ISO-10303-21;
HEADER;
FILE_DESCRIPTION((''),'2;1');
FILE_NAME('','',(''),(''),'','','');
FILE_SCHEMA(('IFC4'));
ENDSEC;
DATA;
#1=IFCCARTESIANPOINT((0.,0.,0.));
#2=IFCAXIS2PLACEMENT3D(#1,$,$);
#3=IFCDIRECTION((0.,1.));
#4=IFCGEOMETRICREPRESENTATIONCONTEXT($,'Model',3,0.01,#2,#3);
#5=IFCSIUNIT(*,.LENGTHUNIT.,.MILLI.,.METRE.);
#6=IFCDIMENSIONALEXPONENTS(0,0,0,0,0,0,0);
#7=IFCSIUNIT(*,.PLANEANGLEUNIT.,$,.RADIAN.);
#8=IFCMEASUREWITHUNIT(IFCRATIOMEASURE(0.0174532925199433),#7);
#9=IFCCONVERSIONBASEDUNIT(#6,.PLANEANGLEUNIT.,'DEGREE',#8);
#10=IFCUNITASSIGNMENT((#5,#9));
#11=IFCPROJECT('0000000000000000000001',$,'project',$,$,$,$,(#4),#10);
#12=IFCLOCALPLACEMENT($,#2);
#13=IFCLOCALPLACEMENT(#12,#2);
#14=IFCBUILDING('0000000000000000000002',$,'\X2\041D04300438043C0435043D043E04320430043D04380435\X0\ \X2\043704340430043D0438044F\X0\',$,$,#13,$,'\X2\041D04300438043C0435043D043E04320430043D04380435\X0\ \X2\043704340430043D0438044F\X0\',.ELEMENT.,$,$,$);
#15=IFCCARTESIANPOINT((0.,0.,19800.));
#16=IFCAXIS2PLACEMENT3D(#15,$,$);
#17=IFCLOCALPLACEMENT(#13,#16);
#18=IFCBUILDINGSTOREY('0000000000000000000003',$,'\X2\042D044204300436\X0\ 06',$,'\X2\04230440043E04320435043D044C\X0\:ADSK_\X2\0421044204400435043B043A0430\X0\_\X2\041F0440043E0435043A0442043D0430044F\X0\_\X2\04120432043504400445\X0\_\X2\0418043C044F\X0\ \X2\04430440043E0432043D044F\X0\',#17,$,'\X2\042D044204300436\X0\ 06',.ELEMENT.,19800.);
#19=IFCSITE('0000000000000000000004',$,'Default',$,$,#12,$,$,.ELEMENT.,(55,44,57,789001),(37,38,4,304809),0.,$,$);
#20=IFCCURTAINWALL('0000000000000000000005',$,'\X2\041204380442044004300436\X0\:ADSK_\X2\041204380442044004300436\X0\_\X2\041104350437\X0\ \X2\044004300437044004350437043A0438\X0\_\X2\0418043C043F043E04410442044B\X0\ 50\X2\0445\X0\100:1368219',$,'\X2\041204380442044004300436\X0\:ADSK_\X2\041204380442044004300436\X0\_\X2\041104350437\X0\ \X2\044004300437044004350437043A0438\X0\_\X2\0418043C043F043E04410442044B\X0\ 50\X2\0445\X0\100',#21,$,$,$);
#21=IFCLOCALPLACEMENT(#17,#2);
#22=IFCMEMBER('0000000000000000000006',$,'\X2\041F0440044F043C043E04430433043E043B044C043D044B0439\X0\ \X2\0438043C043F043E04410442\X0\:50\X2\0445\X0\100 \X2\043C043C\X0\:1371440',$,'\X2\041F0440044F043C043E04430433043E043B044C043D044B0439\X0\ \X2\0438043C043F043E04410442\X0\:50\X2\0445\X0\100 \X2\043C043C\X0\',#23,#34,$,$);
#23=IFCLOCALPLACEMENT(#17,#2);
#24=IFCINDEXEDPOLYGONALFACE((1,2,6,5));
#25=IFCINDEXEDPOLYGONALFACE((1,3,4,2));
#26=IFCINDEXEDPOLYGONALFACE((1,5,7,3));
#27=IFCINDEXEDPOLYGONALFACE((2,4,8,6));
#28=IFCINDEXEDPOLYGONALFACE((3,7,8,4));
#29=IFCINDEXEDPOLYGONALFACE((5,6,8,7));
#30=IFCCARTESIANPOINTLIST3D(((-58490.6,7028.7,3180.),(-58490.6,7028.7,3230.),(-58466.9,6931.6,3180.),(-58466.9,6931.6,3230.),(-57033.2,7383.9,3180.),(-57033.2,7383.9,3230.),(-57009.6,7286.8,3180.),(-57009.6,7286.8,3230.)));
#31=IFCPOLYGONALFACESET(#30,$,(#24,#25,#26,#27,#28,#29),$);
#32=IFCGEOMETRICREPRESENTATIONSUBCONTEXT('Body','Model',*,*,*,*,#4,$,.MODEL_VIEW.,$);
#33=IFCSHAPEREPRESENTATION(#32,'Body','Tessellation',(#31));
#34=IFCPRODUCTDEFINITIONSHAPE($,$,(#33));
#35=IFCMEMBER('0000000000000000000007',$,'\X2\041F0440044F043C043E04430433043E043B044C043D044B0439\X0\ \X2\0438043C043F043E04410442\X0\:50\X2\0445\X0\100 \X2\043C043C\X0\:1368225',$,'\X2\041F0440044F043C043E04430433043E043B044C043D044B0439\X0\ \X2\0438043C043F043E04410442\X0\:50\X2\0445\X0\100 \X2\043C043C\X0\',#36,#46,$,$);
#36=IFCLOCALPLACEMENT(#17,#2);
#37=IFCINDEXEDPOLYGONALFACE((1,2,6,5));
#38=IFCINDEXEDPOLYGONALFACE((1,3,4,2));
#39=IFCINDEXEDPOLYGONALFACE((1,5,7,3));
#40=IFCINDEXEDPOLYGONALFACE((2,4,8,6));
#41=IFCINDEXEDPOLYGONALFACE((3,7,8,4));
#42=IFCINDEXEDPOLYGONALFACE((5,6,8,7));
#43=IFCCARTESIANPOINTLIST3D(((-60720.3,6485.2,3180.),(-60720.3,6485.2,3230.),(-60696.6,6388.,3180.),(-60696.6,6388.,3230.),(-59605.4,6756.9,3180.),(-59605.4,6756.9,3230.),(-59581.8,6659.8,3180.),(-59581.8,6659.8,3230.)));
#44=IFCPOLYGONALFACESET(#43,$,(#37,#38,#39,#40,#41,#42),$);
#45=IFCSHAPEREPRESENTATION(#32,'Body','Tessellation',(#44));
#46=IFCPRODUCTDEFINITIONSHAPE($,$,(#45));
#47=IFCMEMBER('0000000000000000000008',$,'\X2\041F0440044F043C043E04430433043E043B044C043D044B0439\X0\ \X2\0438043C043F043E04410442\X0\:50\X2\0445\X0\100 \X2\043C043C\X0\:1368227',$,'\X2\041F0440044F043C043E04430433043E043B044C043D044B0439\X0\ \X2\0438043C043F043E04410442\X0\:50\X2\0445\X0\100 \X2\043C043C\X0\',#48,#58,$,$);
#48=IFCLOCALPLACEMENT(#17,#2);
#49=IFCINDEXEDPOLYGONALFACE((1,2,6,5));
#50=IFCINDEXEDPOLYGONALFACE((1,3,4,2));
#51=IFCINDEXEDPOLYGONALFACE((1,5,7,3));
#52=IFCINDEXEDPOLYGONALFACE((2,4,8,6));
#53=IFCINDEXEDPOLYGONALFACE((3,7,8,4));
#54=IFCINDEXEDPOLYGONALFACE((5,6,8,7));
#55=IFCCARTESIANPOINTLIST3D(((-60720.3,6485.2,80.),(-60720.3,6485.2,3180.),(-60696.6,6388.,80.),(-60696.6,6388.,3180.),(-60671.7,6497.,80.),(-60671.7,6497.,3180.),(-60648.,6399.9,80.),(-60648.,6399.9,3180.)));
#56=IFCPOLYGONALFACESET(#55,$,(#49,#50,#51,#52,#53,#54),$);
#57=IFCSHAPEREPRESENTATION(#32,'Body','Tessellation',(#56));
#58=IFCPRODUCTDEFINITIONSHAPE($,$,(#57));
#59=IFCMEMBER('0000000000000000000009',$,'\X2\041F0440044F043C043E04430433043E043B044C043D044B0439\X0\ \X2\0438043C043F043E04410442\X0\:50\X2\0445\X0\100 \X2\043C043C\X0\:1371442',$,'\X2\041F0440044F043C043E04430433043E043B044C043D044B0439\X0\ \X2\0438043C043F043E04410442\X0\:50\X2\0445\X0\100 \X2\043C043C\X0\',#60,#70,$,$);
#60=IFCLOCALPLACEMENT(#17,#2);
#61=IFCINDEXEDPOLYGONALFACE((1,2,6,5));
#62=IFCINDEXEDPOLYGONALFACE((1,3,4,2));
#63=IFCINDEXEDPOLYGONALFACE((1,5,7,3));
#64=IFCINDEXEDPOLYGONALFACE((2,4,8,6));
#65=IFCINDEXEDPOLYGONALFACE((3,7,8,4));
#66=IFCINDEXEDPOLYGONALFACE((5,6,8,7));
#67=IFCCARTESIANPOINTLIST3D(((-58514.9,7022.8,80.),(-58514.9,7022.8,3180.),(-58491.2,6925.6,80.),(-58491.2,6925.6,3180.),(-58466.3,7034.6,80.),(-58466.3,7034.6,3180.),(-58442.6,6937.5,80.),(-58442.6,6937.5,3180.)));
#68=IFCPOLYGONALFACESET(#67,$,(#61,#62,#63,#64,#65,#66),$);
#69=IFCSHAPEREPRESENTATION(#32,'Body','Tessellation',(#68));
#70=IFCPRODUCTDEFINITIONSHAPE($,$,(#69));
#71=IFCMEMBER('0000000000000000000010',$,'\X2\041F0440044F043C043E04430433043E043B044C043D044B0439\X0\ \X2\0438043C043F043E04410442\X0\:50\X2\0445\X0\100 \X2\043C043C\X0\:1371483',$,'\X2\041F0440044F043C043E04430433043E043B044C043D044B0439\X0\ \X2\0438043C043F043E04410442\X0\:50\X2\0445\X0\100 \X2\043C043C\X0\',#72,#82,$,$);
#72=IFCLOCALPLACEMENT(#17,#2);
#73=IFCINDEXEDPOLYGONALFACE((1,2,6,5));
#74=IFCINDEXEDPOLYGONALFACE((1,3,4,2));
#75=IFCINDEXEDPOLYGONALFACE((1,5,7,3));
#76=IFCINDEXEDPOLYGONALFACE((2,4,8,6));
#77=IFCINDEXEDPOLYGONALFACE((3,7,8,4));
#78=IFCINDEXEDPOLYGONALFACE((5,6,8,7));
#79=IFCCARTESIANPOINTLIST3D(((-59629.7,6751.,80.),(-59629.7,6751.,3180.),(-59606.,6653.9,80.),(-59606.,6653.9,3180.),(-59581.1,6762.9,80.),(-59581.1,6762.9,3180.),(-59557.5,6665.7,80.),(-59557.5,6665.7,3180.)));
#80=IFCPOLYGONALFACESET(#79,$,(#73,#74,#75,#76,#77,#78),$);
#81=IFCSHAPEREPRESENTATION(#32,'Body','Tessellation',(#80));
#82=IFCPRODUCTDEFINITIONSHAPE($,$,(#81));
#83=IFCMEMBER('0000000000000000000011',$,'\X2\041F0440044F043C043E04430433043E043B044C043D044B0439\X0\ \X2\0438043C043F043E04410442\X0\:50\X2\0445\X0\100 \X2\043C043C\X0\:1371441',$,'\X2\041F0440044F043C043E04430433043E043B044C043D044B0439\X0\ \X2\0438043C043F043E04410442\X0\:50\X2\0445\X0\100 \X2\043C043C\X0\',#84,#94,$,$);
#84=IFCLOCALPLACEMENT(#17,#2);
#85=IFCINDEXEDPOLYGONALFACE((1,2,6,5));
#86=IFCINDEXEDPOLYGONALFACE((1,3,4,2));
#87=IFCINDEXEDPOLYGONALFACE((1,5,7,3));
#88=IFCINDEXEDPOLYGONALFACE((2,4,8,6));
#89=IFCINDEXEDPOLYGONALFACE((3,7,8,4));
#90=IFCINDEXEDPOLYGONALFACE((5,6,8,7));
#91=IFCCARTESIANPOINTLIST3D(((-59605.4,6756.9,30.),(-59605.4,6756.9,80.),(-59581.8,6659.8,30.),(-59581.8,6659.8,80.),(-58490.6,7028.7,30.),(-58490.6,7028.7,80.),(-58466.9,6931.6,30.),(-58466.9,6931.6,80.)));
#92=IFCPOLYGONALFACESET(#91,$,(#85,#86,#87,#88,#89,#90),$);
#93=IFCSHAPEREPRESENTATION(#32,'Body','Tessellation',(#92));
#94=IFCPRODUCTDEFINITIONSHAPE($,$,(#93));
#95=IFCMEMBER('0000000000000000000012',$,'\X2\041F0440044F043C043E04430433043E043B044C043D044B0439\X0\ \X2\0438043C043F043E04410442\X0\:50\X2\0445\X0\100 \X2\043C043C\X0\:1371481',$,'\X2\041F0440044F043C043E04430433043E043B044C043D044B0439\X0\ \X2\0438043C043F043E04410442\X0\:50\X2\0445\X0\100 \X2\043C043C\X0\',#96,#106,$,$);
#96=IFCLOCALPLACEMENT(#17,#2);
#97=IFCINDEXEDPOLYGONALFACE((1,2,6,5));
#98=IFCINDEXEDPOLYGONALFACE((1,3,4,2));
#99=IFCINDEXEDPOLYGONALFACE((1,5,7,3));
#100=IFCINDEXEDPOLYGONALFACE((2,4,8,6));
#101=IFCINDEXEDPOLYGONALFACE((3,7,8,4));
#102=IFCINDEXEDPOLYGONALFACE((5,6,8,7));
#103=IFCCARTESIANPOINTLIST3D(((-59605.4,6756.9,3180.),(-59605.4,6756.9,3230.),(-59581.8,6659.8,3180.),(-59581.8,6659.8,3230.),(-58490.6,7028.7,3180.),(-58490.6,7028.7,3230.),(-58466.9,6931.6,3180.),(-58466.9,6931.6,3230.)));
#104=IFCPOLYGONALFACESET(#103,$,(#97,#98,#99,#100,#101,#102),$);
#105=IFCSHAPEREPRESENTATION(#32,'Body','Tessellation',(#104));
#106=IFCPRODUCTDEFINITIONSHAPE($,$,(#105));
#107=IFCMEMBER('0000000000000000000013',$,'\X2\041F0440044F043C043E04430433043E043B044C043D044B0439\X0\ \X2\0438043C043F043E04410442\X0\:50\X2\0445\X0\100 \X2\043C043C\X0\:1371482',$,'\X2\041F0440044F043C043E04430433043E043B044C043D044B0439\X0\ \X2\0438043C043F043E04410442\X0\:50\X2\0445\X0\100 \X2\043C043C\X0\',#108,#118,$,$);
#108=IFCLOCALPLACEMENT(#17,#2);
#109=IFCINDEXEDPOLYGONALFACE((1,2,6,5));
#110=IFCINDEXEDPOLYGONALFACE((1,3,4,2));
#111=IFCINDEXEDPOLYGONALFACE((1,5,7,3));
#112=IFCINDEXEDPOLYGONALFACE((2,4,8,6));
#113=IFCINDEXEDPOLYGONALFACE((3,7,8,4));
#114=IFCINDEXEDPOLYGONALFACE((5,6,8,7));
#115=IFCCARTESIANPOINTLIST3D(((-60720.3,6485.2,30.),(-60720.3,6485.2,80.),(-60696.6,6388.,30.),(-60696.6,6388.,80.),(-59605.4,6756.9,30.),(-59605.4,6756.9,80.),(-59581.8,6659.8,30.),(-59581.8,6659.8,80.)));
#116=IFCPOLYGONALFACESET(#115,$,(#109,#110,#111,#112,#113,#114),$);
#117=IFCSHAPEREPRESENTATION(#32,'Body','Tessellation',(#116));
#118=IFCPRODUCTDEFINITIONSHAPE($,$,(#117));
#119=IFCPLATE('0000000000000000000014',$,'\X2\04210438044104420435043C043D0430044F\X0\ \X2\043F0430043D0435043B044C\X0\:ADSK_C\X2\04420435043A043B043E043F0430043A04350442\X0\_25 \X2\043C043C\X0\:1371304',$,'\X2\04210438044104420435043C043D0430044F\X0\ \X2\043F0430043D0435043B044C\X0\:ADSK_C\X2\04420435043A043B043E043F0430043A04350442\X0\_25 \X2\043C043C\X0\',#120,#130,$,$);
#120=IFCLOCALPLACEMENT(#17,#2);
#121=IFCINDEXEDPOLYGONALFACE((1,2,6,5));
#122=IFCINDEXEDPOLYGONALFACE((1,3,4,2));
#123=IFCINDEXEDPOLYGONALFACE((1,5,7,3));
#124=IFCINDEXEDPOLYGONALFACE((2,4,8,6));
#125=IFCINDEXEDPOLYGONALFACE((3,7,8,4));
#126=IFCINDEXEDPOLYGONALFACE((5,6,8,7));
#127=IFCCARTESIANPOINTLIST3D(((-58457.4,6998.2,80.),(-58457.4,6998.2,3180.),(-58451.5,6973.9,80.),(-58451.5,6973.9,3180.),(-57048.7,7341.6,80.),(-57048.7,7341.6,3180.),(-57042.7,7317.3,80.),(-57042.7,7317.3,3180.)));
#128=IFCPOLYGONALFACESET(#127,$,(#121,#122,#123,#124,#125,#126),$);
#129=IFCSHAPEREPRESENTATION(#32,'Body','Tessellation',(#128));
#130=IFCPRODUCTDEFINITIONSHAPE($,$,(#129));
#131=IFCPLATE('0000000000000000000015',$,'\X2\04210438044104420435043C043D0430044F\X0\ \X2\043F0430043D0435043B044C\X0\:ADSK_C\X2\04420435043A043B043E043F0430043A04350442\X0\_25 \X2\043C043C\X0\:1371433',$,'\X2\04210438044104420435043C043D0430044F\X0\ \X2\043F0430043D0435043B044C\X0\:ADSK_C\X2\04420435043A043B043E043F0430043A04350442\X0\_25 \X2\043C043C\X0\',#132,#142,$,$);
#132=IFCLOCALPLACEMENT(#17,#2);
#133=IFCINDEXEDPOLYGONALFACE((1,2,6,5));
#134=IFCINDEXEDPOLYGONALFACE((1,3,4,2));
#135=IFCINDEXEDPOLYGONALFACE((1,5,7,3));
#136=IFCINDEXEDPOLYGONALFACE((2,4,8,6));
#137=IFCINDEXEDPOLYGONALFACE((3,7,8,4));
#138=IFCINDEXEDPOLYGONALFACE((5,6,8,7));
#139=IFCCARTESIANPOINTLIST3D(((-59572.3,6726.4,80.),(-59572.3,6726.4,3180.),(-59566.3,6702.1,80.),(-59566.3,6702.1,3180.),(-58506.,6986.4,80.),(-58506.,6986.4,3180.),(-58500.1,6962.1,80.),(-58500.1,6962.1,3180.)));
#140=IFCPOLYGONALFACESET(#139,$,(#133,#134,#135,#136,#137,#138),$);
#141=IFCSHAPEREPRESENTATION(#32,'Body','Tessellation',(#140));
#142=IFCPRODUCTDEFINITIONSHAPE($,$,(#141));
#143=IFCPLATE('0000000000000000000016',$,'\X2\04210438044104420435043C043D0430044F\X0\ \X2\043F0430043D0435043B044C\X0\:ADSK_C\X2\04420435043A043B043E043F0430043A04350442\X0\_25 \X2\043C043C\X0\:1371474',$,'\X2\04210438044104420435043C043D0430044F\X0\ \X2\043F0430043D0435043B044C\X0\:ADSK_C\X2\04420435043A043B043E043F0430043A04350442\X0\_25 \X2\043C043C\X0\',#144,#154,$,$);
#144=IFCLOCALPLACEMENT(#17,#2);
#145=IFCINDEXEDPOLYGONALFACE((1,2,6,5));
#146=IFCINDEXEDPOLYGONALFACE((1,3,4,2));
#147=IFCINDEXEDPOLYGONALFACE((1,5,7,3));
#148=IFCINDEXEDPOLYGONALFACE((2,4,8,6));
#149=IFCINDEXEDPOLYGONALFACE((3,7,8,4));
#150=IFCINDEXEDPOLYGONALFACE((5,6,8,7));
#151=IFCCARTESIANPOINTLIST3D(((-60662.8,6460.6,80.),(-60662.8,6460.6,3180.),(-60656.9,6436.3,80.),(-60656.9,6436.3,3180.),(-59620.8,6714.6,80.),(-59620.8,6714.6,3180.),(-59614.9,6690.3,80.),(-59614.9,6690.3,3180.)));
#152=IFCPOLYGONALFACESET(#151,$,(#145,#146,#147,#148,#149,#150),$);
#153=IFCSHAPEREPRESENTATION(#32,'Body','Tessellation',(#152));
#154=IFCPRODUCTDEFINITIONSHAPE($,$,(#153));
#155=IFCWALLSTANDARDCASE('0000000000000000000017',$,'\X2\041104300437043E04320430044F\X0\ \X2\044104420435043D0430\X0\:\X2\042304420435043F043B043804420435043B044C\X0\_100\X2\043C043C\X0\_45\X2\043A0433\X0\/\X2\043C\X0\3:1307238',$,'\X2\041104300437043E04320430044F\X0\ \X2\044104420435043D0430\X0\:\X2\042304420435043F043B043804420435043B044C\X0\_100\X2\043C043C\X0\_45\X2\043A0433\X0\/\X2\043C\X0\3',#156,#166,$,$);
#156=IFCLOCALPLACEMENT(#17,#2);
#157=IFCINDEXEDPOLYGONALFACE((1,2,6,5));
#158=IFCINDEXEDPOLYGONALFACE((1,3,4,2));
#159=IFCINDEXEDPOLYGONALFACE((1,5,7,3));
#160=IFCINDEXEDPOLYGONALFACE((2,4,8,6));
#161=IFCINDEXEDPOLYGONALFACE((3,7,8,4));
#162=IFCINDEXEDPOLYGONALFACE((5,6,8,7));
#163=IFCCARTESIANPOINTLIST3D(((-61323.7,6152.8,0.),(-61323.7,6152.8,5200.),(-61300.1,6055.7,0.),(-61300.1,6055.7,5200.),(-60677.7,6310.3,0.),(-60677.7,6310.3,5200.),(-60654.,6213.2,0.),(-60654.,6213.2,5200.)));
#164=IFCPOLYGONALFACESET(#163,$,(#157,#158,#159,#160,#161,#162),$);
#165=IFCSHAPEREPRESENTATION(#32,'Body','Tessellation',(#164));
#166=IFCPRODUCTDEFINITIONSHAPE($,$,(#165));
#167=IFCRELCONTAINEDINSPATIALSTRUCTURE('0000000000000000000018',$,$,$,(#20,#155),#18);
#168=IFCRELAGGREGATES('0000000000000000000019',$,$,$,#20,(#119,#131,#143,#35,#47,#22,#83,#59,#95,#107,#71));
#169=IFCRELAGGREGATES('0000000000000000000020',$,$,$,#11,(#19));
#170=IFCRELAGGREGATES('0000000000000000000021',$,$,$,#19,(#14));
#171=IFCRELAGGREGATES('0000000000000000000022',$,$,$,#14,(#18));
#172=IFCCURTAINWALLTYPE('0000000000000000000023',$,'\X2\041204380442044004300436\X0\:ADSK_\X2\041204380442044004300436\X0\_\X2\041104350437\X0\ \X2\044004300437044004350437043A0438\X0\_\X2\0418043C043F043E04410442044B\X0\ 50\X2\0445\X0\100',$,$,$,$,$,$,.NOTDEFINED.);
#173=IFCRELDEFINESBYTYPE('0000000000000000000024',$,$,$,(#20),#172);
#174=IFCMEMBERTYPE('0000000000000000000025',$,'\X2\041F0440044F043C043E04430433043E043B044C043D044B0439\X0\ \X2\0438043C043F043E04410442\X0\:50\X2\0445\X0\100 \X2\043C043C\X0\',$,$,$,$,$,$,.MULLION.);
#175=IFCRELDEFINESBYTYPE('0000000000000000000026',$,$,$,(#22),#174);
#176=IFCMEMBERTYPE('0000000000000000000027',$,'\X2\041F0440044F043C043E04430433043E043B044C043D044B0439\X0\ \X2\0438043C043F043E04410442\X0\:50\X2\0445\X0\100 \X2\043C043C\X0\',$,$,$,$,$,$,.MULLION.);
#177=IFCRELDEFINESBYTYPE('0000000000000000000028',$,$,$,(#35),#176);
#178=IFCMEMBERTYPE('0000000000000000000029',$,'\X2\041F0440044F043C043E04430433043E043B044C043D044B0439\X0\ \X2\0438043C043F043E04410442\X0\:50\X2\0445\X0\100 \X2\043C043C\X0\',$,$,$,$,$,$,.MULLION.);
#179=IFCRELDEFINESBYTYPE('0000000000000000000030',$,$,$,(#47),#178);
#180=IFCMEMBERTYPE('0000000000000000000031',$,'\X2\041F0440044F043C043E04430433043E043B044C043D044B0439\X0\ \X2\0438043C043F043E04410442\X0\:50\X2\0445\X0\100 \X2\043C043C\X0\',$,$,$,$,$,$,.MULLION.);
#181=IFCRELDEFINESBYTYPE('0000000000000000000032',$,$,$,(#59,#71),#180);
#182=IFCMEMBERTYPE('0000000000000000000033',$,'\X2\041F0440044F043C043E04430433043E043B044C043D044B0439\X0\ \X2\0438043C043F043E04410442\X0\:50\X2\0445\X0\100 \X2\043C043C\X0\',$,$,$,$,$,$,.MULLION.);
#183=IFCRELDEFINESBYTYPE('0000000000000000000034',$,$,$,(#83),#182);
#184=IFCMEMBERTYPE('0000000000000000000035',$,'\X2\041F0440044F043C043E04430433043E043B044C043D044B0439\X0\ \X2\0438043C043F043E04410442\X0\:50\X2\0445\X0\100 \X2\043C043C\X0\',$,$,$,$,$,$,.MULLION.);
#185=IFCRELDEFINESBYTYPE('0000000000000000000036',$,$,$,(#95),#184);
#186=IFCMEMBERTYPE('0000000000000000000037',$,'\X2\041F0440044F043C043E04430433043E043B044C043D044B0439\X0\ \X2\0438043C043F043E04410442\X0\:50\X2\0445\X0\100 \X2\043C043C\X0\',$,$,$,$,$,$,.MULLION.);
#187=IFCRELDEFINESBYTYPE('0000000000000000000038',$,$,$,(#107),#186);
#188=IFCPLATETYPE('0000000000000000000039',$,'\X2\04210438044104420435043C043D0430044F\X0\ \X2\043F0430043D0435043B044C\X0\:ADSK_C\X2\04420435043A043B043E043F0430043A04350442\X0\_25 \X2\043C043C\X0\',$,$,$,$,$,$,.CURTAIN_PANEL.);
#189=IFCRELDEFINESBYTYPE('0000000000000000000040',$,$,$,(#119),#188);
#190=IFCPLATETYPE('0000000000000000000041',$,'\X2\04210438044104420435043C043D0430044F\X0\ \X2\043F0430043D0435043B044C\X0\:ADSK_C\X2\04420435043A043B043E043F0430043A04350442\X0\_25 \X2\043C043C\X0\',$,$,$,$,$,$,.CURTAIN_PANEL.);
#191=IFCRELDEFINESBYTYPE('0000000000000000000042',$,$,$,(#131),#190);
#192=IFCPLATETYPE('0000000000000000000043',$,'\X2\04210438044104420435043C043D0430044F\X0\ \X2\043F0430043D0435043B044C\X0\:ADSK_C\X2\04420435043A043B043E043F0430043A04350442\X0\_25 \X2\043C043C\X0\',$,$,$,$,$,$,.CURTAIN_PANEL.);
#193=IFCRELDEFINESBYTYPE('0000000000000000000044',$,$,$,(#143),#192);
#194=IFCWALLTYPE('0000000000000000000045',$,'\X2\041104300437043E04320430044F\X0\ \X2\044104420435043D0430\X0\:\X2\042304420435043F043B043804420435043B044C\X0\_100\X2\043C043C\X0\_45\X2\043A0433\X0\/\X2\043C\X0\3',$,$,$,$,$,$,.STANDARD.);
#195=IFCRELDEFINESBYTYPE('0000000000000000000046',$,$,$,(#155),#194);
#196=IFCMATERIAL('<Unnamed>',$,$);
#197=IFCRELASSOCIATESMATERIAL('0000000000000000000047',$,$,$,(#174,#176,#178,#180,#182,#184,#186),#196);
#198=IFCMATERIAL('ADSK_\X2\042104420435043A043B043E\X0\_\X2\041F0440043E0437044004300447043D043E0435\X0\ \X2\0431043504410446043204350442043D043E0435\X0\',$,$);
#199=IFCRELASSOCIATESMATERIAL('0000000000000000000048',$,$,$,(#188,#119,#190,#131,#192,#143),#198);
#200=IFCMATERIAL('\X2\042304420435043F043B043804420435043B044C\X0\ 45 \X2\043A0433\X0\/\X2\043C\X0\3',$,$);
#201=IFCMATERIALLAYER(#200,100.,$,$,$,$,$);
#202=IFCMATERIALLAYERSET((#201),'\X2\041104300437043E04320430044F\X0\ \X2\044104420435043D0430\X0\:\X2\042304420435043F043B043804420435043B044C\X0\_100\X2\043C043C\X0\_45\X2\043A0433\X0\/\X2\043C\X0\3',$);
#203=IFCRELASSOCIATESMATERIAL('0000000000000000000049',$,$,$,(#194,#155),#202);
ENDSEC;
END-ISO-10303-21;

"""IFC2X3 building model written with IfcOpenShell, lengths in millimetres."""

from ifc_helpers import new_model, entity, si_unit, converted_unit, direction, frame, frame_2d, origin, origin_2d_with_axis, place, context, subcontext, project, spatial, rectangle, extrude, source, transform, mapped, material, layer, layer_set, layer_usage, type_object, type_shapes, element, aggregate, save


model = new_model("IFC2X3")

# Units and contexts
model_context = context("Model", 3, precision=0.01, world=origin(), true_north=direction((0.0, 1.0)))
body_context = subcontext(model_context, "Body", "Model", "MODEL_VIEW")
ifc_project = project(units=[si_unit("LENGTHUNIT", "METRE", prefix="MILLI"), converted_unit("PLANEANGLEUNIT", "DEGREE", entity("IfcRatioMeasure", 0.0174532925199433), si_unit("PLANEANGLEUNIT", "RADIAN"), dimensions=[0, 0, 0, 0, 0, 0, 0])], contexts=[model_context])

# Site, building, storey
site_placement = place(None, origin())
site = spatial("IfcSite", under=ifc_project, at=site_placement, Name="Default", CompositionType="ELEMENT", RefLatitude=(55, 44, 57, 789001), RefLongitude=(37, 38, 4, 304809), RefElevation=0.0)
building_placement = place(site_placement, origin())
building = spatial("IfcBuilding", under=site, at=building_placement, Name="Наименование здания", LongName="Наименование здания", CompositionType="ELEMENT")
storey_placement = place(building_placement, frame((0.0, 0.0, 19800.0)))
storey = spatial("IfcBuildingStorey", under=building, at=storey_placement, Name="Этаж 06", ObjectType="Уровень:ADSK_Стрелка_Проектная_Вверх_Имя уровня", LongName="Этаж 06", CompositionType="ELEMENT", Elevation=19800.0)

# Curtain wall, members, plates
curtain_wall_type = type_object("IfcCurtainWallType", Name="Витраж:ADSK_Витраж_Без разрезки_Импосты 50х100", PredefinedType="NOTDEFINED")
curtain_wall_placement = place(storey_placement, frame((0.0, 0.0, -19800.0)))
curtain_wall = element("IfcCurtainWall", 1, at=curtain_wall_placement, inside=storey, type_object=curtain_wall_type, Name="Витраж:ADSK_Витраж_Без разрезки_Импосты 50х100:1368219", ObjectType="Витраж:ADSK_Витраж_Без разрезки_Импосты 50х100")
ifc_material_1 = material(Name="<Unnamed>")
member_type_1 = type_object("IfcMemberType", Name="Прямоугольный импост:50х100 мм", PredefinedType="MULLION", material=ifc_material_1)
shared_shape_1 = source(origin(), body_context, "Body", "SweptSolid", [
    extrude(rectangle(XDim=100.0, YDim=50.0, at=origin_2d_with_axis()), frame((-25.0, 0.0, -1500.0), z_axis=(0.0, 0.0, 1.0), x_axis=(0.0, -1.0, 0.0)), (0.0, 0.0, 1.0), 1500.0),
])
type_shapes(member_type_1, [shared_shape_1])
member_1_placement = place(storey_placement, frame((-58478.7, 6980.1, 3230.0), z_axis=(-0.971552, -0.236826, 0.0), x_axis=(0.0, 0.0, 1.0)))
member_1 = element("IfcMember", 2, at=member_1_placement, type_object=member_type_1, Name="Прямоугольный импост:50х100 мм:1371440", ObjectType="Прямоугольный импост:50х100 мм", context=body_context, shape_type="MappedRepresentation", body=[
    mapped(shared_shape_1, transform((0.0, 0.0, 0.0), scale=1.0)),
])
member_type_2 = type_object("IfcMemberType", Name="Прямоугольный импост:50х100 мм", PredefinedType="MULLION", material=ifc_material_1)
shared_shape_2 = source(origin(), body_context, "Body", "SweptSolid", [
    extrude(rectangle(XDim=100.0, YDim=50.0, at=origin_2d_with_axis()), frame((-25.0, 0.0, -1147.5), z_axis=(0.0, 0.0, 1.0), x_axis=(0.0, -1.0, 0.0)), (0.0, 0.0, 1.0), 1147.5),
])
type_shapes(member_type_2, [shared_shape_2])
member_2_placement = place(storey_placement, frame((-60708.5, 6436.6, 3230.0), z_axis=(-0.971552, -0.236826, 0.0), x_axis=(0.0, 0.0, 1.0)))
member_2 = element("IfcMember", 3, at=member_2_placement, type_object=member_type_2, Name="Прямоугольный импост:50х100 мм:1368225", ObjectType="Прямоугольный импост:50х100 мм", context=body_context, shape_type="MappedRepresentation", body=[
    mapped(shared_shape_2, transform((0.0, 0.0, 0.0), scale=1.0)),
])
member_type_3 = type_object("IfcMemberType", Name="Прямоугольный импост:50х100 мм", PredefinedType="MULLION", material=ifc_material_1)
shared_shape_3 = source(origin(), body_context, "Body", "SweptSolid", [
    extrude(rectangle(XDim=100.0, YDim=50.0, at=origin_2d_with_axis()), frame((-25.0, 0.0, -3100.0), z_axis=(0.0, 0.0, 1.0), x_axis=(0.0, -1.0, 0.0)), (0.0, 0.0, 1.0), 3100.0),
])
type_shapes(member_type_3, [shared_shape_3])
member_3_placement = place(storey_placement, frame((-60708.5, 6436.6, 80.0), z_axis=(0.0, 0.0, -1.0), x_axis=(-0.971552, -0.236826, 0.0)))
member_3 = element("IfcMember", 4, at=member_3_placement, type_object=member_type_3, Name="Прямоугольный импост:50х100 мм:1368227", ObjectType="Прямоугольный импост:50х100 мм", context=body_context, shape_type="MappedRepresentation", body=[
    mapped(shared_shape_3, transform((0.0, 0.0, 0.0), scale=1.0)),
])
member_type_4 = type_object("IfcMemberType", Name="Прямоугольный импост:50х100 мм", PredefinedType="MULLION", material=ifc_material_1)
shared_shape_4 = source(origin(), body_context, "Body", "SweptSolid", [
    extrude(rectangle(XDim=100.0, YDim=50.0, at=origin_2d_with_axis()), frame((0.0, 0.0, -3100.0), z_axis=(0.0, 0.0, 1.0), x_axis=(0.0, -1.0, 0.0)), (0.0, 0.0, 1.0), 3100.0),
])
type_shapes(member_type_4, [shared_shape_4])
member_4_placement = place(storey_placement, frame((-58478.7, 6980.1, 80.0), z_axis=(0.0, 0.0, -1.0), x_axis=(-0.971552, -0.236826, 0.0)))
member_4 = element("IfcMember", 5, at=member_4_placement, type_object=member_type_4, Name="Прямоугольный импост:50х100 мм:1371442", ObjectType="Прямоугольный импост:50х100 мм", context=body_context, shape_type="MappedRepresentation", body=[
    mapped(shared_shape_4, transform((0.0, 0.0, 0.0), scale=1.0)),
])
member_5_placement = place(storey_placement, frame((-59593.6, 6708.4, 80.0), z_axis=(0.0, 0.0, -1.0), x_axis=(-0.971552, -0.236826, 0.0)))
member_5 = element("IfcMember", 6, at=member_5_placement, type_object=member_type_4, Name="Прямоугольный импост:50х100 мм:1371483", ObjectType="Прямоугольный импост:50х100 мм", context=body_context, shape_type="MappedRepresentation", body=[
    mapped(shared_shape_4, transform((0.0, 0.0, 0.0), scale=1.0)),
])
member_type_5 = type_object("IfcMemberType", Name="Прямоугольный импост:50х100 мм", PredefinedType="MULLION", material=ifc_material_1)
shared_shape_5 = source(origin(), body_context, "Body", "SweptSolid", [
    extrude(rectangle(XDim=100.0, YDim=50.0, at=origin_2d_with_axis()), frame((-25.0, 0.0, -1147.5), z_axis=(0.0, 0.0, 1.0), x_axis=(0.0, -1.0, 0.0)), (0.0, 0.0, 1.0), 1147.5),
])
type_shapes(member_type_5, [shared_shape_5])
member_6_placement = place(storey_placement, frame((-58478.7, 6980.1, 30.0), z_axis=(0.971552, 0.236826, 0.0), x_axis=(0.0, 0.0, -1.0)))
member_6 = element("IfcMember", 7, at=member_6_placement, type_object=member_type_5, Name="Прямоугольный импост:50х100 мм:1371441", ObjectType="Прямоугольный импост:50х100 мм", context=body_context, shape_type="MappedRepresentation", body=[
    mapped(shared_shape_5, transform((0.0, 0.0, 0.0), scale=1.0)),
])
member_type_6 = type_object("IfcMemberType", Name="Прямоугольный импост:50х100 мм", PredefinedType="MULLION", material=ifc_material_1)
shared_shape_6 = source(origin(), body_context, "Body", "SweptSolid", [
    extrude(rectangle(XDim=100.0, YDim=50.0, at=origin_2d_with_axis()), frame((-25.0, 0.0, -1147.5), z_axis=(0.0, 0.0, 1.0), x_axis=(0.0, -1.0, 0.0)), (0.0, 0.0, 1.0), 1147.5),
])
type_shapes(member_type_6, [shared_shape_6])
member_7_placement = place(storey_placement, frame((-59593.6, 6708.4, 3230.0), z_axis=(-0.971552, -0.236826, 0.0), x_axis=(0.0, 0.0, 1.0)))
member_7 = element("IfcMember", 8, at=member_7_placement, type_object=member_type_6, Name="Прямоугольный импост:50х100 мм:1371481", ObjectType="Прямоугольный импост:50х100 мм", context=body_context, shape_type="MappedRepresentation", body=[
    mapped(shared_shape_6, transform((0.0, 0.0, 0.0), scale=1.0)),
])
member_type_7 = type_object("IfcMemberType", Name="Прямоугольный импост:50х100 мм", PredefinedType="MULLION", material=ifc_material_1)
shared_shape_7 = source(origin(), body_context, "Body", "SweptSolid", [
    extrude(rectangle(XDim=100.0, YDim=50.0, at=origin_2d_with_axis()), frame((-25.0, 0.0, -1147.5), z_axis=(0.0, 0.0, 1.0), x_axis=(0.0, -1.0, 0.0)), (0.0, 0.0, 1.0), 1147.5),
])
type_shapes(member_type_7, [shared_shape_7])
member_8_placement = place(storey_placement, frame((-59593.6, 6708.4, 30.0), z_axis=(0.971552, 0.236826, 0.0), x_axis=(0.0, 0.0, -1.0)))
member_8 = element("IfcMember", 9, at=member_8_placement, type_object=member_type_7, Name="Прямоугольный импост:50х100 мм:1371482", ObjectType="Прямоугольный импост:50х100 мм", context=body_context, shape_type="MappedRepresentation", body=[
    mapped(shared_shape_7, transform((0.0, 0.0, 0.0), scale=1.0)),
])
ifc_material_2 = material(Name="ADSK_Стекло_Прозрачное бесцветное")
plate_type_1 = type_object("IfcPlateType", Name="Системная панель:ADSK_Cтеклопакет_25 мм", PredefinedType="CURTAIN_PANEL", material=ifc_material_2)
shared_shape_8 = source(origin(), body_context, "Body", "SweptSolid", [
    extrude(rectangle(XDim=25.0, YDim=1450.0, at=frame_2d((0.0, 0.0), x_axis=(1.0, 0.0))), frame((0.0, 0.0, 0.0), z_axis=(0.0, 0.0, 1.0), x_axis=(0.0, 1.0, 0.0)), (0.0, 0.0, 1.0), 3100.0),
])
type_shapes(plate_type_1, [shared_shape_8])
plate_1_placement = place(curtain_wall_placement, frame((-57750.1, 7157.7, 19880.0), z_axis=(0.0, 0.0, 1.0), x_axis=(-0.971552, -0.236826, 0.0)))
plate_1 = element("IfcPlate", 10, at=plate_1_placement, type_object=plate_type_1, material=ifc_material_2, Name="Системная панель:ADSK_Cтеклопакет_25 мм:1371304", ObjectType="Системная панель:ADSK_Cтеклопакет_25 мм", context=body_context, shape_type="MappedRepresentation", body=[
    mapped(shared_shape_8, transform((0.0, 0.0, 0.0), scale=1.0)),
])
plate_type_2 = type_object("IfcPlateType", Name="Системная панель:ADSK_Cтеклопакет_25 мм", PredefinedType="CURTAIN_PANEL", material=ifc_material_2)
shared_shape_9 = source(origin(), body_context, "Body", "SweptSolid", [
    extrude(rectangle(XDim=25.0, YDim=1097.5, at=origin_2d_with_axis()), frame((0.0, 0.0, 0.0), z_axis=(0.0, 0.0, 1.0), x_axis=(0.0, 1.0, 0.0)), (0.0, 0.0, 1.0), 3100.0),
])
type_shapes(plate_type_2, [shared_shape_9])
plate_2_placement = place(curtain_wall_placement, frame((-59036.2, 6844.2, 19880.0), z_axis=(0.0, 0.0, 1.0), x_axis=(-0.971552, -0.236826, 0.0)))
plate_2 = element("IfcPlate", 11, at=plate_2_placement, type_object=plate_type_2, material=ifc_material_2, Name="Системная панель:ADSK_Cтеклопакет_25 мм:1371433", ObjectType="Системная панель:ADSK_Cтеклопакет_25 мм", context=body_context, shape_type="MappedRepresentation", body=[
    mapped(shared_shape_9, transform((0.0, 0.0, 0.0), scale=1.0)),
])
plate_type_3 = type_object("IfcPlateType", Name="Системная панель:ADSK_Cтеклопакет_25 мм", PredefinedType="CURTAIN_PANEL", material=ifc_material_2)
shared_shape_10 = source(origin(), body_context, "Body", "SweptSolid", [
    extrude(rectangle(XDim=25.0, YDim=1072.5, at=frame_2d((0.0, 0.0), x_axis=(1.0, 0.0))), frame((0.0, 0.0, 0.0), z_axis=(0.0, 0.0, 1.0), x_axis=(0.0, 1.0, 0.0)), (0.0, 0.0, 1.0), 3100.0),
])
type_shapes(plate_type_3, [shared_shape_10])
plate_3_placement = place(curtain_wall_placement, frame((-60138.9, 6575.5, 19880.0), z_axis=(0.0, 0.0, 1.0), x_axis=(-0.971552, -0.236826, 0.0)))
plate_3 = element("IfcPlate", 12, at=plate_3_placement, type_object=plate_type_3, material=ifc_material_2, Name="Системная панель:ADSK_Cтеклопакет_25 мм:1371474", ObjectType="Системная панель:ADSK_Cтеклопакет_25 мм", context=body_context, shape_type="MappedRepresentation", body=[
    mapped(shared_shape_10, transform((0.0, 0.0, 0.0), scale=1.0)),
])
aggregate(curtain_wall, [plate_1, plate_2, plate_3, member_2, member_3, member_1, member_6, member_4, member_7, member_8, member_5])

# Shared definitions
ifc_material_3 = material(Name="Утеплитель 45 кг/м3")
ifc_layer_1 = layer(ifc_material_3, 100.0)
ifc_layer_set_1 = layer_set([ifc_layer_1], Name="Базовая стена:Утеплитель_100мм_45кг/м3")
wall_type_1 = type_object("IfcWallType", Name="Базовая стена:Утеплитель_100мм_45кг/м3", PredefinedType="STANDARD", material=ifc_layer_set_1)

# Wall
ifc_layer_usage_1 = layer_usage(ifc_layer_set_1, "AXIS2", "NEGATIVE", 50.0)
wall_1_placement = place(storey_placement, frame((-61311.9, 6104.2, 0.0), z_axis=(0.0, 0.0, 1.0), x_axis=(0.971552, 0.236826, 0.0)))
element("IfcWallStandardCase", 13, at=wall_1_placement, inside=storey, type_object=wall_type_1, material=ifc_layer_usage_1, Name="Базовая стена:Утеплитель_100мм_45кг/м3:1307238", ObjectType="Базовая стена:Утеплитель_100мм_45кг/м3", context=body_context, shape_type="SweptSolid", body=[
    extrude(rectangle(XDim=665.0, YDim=100.0, at=frame_2d((332.5, 0.0), x_axis=(-1.0, 0.0))), origin(), (0.0, 0.0, 1.0), 5200.0),
])

save(model, "model.ifc")
